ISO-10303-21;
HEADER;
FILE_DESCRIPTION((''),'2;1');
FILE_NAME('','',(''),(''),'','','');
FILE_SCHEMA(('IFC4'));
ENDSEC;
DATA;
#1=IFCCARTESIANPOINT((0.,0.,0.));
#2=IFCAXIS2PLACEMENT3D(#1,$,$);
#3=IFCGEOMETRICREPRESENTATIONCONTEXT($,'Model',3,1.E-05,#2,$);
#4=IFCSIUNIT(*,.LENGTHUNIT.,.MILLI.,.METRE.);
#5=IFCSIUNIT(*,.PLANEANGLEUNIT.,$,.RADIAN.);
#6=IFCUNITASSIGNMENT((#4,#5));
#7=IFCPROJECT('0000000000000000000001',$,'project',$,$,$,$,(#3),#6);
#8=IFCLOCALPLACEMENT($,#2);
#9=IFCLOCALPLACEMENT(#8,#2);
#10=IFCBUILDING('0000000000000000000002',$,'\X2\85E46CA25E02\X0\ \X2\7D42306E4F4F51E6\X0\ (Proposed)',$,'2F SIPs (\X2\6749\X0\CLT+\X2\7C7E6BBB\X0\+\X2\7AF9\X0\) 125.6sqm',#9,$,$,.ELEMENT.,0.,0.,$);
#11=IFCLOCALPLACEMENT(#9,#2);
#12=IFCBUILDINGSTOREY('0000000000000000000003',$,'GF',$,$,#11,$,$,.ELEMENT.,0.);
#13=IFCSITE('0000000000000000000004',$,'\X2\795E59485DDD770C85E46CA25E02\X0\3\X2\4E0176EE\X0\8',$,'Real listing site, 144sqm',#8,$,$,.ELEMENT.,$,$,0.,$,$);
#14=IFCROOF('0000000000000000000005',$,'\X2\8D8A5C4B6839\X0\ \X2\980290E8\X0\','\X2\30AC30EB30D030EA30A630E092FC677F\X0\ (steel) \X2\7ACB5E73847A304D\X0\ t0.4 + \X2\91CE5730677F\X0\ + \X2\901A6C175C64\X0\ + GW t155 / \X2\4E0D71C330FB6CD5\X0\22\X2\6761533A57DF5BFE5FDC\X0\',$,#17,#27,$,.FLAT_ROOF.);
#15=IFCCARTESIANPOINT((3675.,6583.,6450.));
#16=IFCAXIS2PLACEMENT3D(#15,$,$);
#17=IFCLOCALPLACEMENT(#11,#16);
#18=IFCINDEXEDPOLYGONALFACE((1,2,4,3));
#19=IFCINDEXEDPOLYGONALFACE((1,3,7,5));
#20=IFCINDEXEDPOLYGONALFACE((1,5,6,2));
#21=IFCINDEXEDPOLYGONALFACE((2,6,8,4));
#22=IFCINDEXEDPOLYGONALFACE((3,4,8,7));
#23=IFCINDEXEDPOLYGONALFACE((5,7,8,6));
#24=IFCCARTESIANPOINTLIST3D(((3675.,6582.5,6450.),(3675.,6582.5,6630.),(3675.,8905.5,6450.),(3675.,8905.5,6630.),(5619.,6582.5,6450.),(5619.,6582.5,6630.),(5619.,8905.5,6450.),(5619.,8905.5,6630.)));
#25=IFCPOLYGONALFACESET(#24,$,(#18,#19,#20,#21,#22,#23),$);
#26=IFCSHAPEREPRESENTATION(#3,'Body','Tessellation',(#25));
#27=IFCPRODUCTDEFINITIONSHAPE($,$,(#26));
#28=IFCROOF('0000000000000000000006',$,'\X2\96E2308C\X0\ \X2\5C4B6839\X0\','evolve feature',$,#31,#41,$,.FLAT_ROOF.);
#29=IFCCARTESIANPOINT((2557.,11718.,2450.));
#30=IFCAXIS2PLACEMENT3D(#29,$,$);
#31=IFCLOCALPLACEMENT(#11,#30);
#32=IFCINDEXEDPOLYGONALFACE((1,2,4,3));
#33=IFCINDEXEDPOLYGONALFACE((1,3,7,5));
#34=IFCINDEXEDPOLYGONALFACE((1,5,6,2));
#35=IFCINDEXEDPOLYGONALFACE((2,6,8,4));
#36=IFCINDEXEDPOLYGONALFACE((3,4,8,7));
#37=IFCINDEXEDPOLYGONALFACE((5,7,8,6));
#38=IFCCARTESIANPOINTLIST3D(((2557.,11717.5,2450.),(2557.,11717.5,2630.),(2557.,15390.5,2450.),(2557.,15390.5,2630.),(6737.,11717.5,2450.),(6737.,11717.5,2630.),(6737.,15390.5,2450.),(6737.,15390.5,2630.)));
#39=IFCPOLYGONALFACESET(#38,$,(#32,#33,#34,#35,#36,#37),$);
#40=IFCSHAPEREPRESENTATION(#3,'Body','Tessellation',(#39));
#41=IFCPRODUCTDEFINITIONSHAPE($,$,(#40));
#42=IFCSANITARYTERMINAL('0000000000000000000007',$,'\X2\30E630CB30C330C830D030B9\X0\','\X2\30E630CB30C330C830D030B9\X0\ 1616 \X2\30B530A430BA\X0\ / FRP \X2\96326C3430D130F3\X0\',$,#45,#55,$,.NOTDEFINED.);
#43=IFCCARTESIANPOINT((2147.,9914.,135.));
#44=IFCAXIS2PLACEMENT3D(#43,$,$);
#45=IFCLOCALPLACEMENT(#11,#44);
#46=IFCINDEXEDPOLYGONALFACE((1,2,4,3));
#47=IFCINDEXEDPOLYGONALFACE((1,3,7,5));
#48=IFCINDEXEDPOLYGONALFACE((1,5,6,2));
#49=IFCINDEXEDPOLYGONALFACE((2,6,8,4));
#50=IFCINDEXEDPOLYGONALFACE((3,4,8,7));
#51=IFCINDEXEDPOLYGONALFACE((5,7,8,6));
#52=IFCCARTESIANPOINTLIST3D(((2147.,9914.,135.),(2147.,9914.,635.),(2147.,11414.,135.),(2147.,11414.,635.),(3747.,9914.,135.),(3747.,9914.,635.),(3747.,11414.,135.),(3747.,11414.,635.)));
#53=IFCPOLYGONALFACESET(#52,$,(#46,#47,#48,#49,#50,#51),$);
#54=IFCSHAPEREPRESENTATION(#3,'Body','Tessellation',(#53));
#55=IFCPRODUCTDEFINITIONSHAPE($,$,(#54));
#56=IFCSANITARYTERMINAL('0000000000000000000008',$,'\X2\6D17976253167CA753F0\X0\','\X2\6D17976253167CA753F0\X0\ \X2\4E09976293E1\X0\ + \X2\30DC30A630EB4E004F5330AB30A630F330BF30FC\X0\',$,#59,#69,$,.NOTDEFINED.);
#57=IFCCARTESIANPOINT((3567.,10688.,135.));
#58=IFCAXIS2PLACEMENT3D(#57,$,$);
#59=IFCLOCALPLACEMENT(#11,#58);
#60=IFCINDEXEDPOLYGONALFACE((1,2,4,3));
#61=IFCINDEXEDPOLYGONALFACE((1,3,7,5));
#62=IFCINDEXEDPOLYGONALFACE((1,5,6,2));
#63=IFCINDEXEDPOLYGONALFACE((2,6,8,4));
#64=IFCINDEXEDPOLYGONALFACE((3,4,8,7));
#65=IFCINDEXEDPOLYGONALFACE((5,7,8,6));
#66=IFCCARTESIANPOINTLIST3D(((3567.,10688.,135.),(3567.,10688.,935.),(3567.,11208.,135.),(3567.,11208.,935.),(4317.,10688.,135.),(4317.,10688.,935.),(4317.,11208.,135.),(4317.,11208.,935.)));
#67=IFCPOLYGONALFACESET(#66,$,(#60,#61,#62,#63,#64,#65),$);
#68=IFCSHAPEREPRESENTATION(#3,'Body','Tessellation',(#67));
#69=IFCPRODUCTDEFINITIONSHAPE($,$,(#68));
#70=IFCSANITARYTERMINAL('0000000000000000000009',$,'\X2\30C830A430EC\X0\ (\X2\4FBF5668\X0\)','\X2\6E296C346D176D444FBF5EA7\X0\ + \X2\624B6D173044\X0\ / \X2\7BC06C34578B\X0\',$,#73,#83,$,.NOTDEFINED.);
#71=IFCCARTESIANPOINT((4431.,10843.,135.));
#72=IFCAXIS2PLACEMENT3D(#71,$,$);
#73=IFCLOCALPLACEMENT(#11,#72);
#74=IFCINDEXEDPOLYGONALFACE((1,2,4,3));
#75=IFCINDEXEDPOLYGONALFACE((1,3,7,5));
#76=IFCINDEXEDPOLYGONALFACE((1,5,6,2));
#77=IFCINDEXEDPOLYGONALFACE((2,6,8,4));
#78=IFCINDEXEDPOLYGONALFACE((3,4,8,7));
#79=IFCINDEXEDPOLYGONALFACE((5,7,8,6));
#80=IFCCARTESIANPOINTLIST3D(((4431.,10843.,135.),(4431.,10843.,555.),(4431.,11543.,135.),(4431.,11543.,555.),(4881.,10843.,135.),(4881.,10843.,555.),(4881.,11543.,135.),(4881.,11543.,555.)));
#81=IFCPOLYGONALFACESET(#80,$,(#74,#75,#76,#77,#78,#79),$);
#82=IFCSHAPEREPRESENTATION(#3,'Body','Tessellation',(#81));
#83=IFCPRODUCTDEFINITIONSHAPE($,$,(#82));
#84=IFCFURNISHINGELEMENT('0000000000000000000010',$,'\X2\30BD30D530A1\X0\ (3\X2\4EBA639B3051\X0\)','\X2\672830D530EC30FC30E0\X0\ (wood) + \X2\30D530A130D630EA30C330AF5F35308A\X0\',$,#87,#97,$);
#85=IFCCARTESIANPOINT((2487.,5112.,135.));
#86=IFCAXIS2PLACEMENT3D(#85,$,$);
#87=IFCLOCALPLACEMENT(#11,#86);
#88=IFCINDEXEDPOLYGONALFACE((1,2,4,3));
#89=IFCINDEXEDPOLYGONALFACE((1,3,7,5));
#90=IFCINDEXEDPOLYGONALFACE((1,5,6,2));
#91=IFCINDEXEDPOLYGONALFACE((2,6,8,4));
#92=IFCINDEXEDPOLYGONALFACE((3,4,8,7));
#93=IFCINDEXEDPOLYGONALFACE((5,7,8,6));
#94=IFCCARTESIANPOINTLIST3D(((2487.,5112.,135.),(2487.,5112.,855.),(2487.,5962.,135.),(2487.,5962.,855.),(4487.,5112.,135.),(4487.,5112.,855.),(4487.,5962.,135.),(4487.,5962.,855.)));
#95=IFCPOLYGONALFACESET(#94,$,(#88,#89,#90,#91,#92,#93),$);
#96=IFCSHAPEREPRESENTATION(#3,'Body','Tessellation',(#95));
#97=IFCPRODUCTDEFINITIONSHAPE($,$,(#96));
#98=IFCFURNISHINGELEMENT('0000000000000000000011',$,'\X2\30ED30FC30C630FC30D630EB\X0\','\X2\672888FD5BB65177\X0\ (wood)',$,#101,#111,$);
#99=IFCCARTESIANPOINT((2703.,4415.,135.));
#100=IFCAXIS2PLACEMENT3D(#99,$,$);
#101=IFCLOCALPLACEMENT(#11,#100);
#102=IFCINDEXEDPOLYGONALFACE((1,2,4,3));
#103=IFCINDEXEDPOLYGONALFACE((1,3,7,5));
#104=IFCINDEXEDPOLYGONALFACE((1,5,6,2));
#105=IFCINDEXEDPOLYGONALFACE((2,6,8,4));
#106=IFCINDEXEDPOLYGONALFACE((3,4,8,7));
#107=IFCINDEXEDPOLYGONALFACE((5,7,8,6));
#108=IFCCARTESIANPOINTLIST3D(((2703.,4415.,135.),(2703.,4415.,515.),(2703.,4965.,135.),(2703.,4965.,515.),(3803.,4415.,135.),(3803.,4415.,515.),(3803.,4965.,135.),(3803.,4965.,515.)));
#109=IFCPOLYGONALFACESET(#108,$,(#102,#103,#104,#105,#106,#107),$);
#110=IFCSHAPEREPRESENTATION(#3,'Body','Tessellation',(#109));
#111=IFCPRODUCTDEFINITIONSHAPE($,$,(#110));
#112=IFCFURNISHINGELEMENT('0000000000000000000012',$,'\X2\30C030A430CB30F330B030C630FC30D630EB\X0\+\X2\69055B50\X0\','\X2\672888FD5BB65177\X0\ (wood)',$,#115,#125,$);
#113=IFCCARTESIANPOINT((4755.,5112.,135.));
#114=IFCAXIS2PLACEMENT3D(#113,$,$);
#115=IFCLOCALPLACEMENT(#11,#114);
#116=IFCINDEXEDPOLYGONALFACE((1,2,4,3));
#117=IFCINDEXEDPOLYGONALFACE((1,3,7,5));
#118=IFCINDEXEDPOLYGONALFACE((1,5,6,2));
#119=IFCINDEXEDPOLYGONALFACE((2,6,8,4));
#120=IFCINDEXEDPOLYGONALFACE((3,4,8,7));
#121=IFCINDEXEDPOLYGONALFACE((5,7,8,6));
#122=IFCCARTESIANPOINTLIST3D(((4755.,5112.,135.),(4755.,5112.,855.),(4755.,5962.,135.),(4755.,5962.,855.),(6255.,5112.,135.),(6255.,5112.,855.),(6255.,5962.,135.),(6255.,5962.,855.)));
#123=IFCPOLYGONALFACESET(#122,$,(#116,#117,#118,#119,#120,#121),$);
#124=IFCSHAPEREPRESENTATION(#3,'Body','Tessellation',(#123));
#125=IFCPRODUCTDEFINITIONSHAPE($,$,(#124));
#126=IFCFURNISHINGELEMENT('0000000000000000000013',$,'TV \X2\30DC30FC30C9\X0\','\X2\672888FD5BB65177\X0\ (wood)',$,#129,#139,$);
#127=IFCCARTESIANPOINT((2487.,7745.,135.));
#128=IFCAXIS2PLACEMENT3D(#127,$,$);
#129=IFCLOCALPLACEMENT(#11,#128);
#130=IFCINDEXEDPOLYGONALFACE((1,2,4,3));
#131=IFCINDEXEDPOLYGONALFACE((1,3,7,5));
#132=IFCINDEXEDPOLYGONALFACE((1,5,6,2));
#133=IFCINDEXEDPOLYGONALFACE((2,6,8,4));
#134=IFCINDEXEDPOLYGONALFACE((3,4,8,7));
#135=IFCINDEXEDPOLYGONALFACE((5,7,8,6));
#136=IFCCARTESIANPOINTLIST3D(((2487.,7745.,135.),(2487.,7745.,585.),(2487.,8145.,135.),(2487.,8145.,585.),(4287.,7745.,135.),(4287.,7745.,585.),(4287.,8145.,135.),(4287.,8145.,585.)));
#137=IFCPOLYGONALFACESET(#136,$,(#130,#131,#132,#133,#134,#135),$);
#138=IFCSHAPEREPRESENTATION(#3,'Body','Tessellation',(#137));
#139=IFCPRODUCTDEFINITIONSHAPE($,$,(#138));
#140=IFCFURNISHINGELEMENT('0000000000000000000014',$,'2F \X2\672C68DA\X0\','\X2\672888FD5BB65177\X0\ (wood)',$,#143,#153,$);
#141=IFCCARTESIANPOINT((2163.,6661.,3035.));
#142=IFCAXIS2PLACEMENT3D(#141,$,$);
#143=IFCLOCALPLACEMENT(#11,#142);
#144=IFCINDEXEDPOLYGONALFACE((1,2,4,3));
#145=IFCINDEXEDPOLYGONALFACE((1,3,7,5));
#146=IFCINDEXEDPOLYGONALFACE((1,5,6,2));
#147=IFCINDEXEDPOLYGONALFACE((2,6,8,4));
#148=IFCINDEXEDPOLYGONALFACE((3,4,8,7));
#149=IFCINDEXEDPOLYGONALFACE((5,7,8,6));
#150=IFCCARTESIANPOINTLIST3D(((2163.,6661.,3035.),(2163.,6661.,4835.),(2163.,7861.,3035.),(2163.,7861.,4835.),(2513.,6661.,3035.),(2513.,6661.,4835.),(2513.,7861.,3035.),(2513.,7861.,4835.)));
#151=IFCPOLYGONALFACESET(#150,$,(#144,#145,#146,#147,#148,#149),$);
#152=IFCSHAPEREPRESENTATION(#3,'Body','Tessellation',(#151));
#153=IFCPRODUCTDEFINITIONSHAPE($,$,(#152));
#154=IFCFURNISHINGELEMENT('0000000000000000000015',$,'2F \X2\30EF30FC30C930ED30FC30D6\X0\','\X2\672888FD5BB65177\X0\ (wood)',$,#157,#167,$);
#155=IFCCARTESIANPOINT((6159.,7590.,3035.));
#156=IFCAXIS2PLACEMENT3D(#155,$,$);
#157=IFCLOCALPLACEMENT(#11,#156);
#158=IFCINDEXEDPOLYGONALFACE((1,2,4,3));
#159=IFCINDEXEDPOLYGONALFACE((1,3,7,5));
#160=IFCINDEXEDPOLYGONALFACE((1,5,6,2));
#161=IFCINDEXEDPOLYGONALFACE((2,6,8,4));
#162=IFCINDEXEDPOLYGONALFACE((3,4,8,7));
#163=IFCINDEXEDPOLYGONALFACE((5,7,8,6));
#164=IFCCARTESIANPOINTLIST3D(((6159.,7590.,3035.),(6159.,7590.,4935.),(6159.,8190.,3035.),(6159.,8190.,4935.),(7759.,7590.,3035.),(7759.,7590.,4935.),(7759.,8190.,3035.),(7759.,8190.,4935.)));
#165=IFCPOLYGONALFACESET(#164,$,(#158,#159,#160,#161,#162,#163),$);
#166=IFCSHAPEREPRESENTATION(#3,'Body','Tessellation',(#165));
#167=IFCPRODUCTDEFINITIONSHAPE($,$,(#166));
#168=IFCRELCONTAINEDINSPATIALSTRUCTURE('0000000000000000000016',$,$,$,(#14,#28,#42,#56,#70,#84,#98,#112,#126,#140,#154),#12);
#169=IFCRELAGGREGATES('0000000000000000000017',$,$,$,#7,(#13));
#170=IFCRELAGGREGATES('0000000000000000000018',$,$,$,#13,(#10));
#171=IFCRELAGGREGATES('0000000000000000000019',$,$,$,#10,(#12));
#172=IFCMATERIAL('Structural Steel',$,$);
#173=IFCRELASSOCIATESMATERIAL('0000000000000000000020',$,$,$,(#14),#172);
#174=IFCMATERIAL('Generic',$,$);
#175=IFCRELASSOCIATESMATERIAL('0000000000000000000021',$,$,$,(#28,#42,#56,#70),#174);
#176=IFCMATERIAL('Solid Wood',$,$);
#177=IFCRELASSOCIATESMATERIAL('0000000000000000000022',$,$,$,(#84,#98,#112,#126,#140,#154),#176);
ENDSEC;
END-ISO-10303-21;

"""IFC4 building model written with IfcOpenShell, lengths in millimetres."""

from ifc_helpers import new_model, si_unit, frame, frame_2d, origin, place, context, project, spatial, rectangle, extrude, material, element, save


model = new_model("IFC4")

# Units and contexts
model_context = context("Model", 3, precision=1e-05, world=origin())
ifc_project = project(units=[si_unit("LENGTHUNIT", "METRE", prefix="MILLI"), si_unit("PLANEANGLEUNIT", "RADIAN")], contexts=[model_context])

# Site, building, storey
site_placement = place(None, origin())
site = spatial("IfcSite", under=ifc_project, at=site_placement, Name="神奈川県藤沢市3丁目8", ObjectType="Real listing site, 144sqm", CompositionType="ELEMENT", RefElevation=0.0)
building_placement = place(site_placement, origin())
building = spatial("IfcBuilding", under=site, at=building_placement, Name="藤沢市 終の住処 (Proposed)", ObjectType="2F SIPs (杉CLT+籾殻+竹) 125.6sqm", CompositionType="ELEMENT", ElevationOfRefHeight=0.0, ElevationOfTerrain=0.0)
storey_placement = place(building_placement, origin())
storey = spatial("IfcBuildingStorey", under=building, at=storey_placement, Name="GF", CompositionType="ELEMENT", Elevation=0.0)

# Shared definitions
ifc_material_1 = material(Name="Generic")

# Shared definitions
ifc_material_2 = material(Name="Solid Wood")

# Roofs
ifc_material_3 = material(Name="Structural Steel")
roof_1_placement = place(storey_placement, frame((3675.0, 6583.0, 6450.0)))
element("IfcRoof", 1, at=roof_1_placement, inside=storey, material=ifc_material_3, Name="越屋根 頂部", Description="ガルバリウム鋼板 (steel) 立平葺き t0.4 + 野地板 + 通気層 + GW t155 / 不燃・法22条区域対応", PredefinedType="FLAT_ROOF", context=model_context, shape_type="SweptSolid", body=[
    extrude(rectangle(XDim=1944.0, YDim=2323.0, at=frame_2d((972.0, 1161.0))), frame((3675.0, 6583.0, 6450.0)), (0.0, 0.0, 1.0), 180.0),
])
roof_2_placement = place(storey_placement, frame((2557.0, 11718.0, 2450.0)))
element("IfcRoof", 2, at=roof_2_placement, inside=storey, material=ifc_material_1, Name="離れ 屋根", Description="evolve feature", PredefinedType="FLAT_ROOF", context=model_context, shape_type="SweptSolid", body=[
    extrude(rectangle(XDim=4180.0, YDim=3673.0, at=frame_2d((2090.0, 1836.0))), frame((2557.0, 11718.0, 2450.0)), (0.0, 0.0, 1.0), 180.0),
])

# Sanitary terminals
sanitary_terminal_1_placement = place(storey_placement, frame((2147.0, 9914.0, 135.0)))
element("IfcSanitaryTerminal", 3, at=sanitary_terminal_1_placement, inside=storey, material=ifc_material_1, Name="ユニットバス", Description="ユニットバス 1616 サイズ / FRP 防水パン", PredefinedType="NOTDEFINED", context=model_context, shape_type="SweptSolid", body=[
    extrude(rectangle(XDim=1600.0, YDim=1500.0, at=frame_2d((800.0, 750.0))), frame((2147.0, 9914.0, 135.0)), (0.0, 0.0, 1.0), 500.0),
])
sanitary_terminal_2_placement = place(storey_placement, frame((3567.0, 10688.0, 135.0)))
element("IfcSanitaryTerminal", 4, at=sanitary_terminal_2_placement, inside=storey, material=ifc_material_1, Name="洗面化粧台", Description="洗面化粧台 三面鏡 + ボウル一体カウンター", PredefinedType="NOTDEFINED", context=model_context, shape_type="SweptSolid", body=[
    extrude(rectangle(XDim=750.0, YDim=520.0, at=frame_2d((375.0, 260.0))), frame((3567.0, 10688.0, 135.0)), (0.0, 0.0, 1.0), 800.0),
])
sanitary_terminal_3_placement = place(storey_placement, frame((4431.0, 10843.0, 135.0)))
element("IfcSanitaryTerminal", 5, at=sanitary_terminal_3_placement, inside=storey, material=ifc_material_1, Name="トイレ (便器)", Description="温水洗浄便座 + 手洗い / 節水型", PredefinedType="NOTDEFINED", context=model_context, shape_type="SweptSolid", body=[
    extrude(rectangle(XDim=450.0, YDim=700.0, at=frame_2d((225.0, 350.0))), frame((4431.0, 10843.0, 135.0)), (0.0, 0.0, 1.0), 420.0),
])

# Furnishing elements
furnishing_1_placement = place(storey_placement, frame((2487.0, 5112.0, 135.0)))
element("IfcFurnishingElement", 6, at=furnishing_1_placement, inside=storey, material=ifc_material_2, Name="ソファ (3人掛け)", Description="木フレーム (wood) + ファブリック張り", context=model_context, shape_type="SweptSolid", body=[
    extrude(rectangle(XDim=2000.0, YDim=850.0, at=frame_2d((1000.0, 425.0))), frame((2487.0, 5112.0, 135.0)), (0.0, 0.0, 1.0), 720.0),
])
furnishing_2_placement = place(storey_placement, frame((2703.0, 4415.0, 135.0)))
element("IfcFurnishingElement", 7, at=furnishing_2_placement, inside=storey, material=ifc_material_2, Name="ローテーブル", Description="木製家具 (wood)", context=model_context, shape_type="SweptSolid", body=[
    extrude(rectangle(XDim=1100.0, YDim=550.0, at=frame_2d((550.0, 275.0))), frame((2703.0, 4415.0, 135.0)), (0.0, 0.0, 1.0), 380.0),
])
furnishing_3_placement = place(storey_placement, frame((4755.0, 5112.0, 135.0)))
element("IfcFurnishingElement", 8, at=furnishing_3_placement, inside=storey, material=ifc_material_2, Name="ダイニングテーブル+椅子", Description="木製家具 (wood)", context=model_context, shape_type="SweptSolid", body=[
    extrude(rectangle(XDim=1500.0, YDim=850.0, at=frame_2d((750.0, 425.0))), frame((4755.0, 5112.0, 135.0)), (0.0, 0.0, 1.0), 720.0),
])
furnishing_4_placement = place(storey_placement, frame((2487.0, 7745.0, 135.0)))
element("IfcFurnishingElement", 9, at=furnishing_4_placement, inside=storey, material=ifc_material_2, Name="TV ボード", Description="木製家具 (wood)", context=model_context, shape_type="SweptSolid", body=[
    extrude(rectangle(XDim=1800.0, YDim=400.0, at=frame_2d((900.0, 200.0))), frame((2487.0, 7745.0, 135.0)), (0.0, 0.0, 1.0), 450.0),
])
furnishing_5_placement = place(storey_placement, frame((2163.0, 6661.0, 3035.0)))
element("IfcFurnishingElement", 10, at=furnishing_5_placement, inside=storey, material=ifc_material_2, Name="2F 本棚", Description="木製家具 (wood)", context=model_context, shape_type="SweptSolid", body=[
    extrude(rectangle(XDim=350.0, YDim=1200.0, at=frame_2d((175.0, 600.0))), frame((2163.0, 6661.0, 3035.0)), (0.0, 0.0, 1.0), 1800.0),
])
furnishing_6_placement = place(storey_placement, frame((6159.0, 7590.0, 3035.0)))
element("IfcFurnishingElement", 11, at=furnishing_6_placement, inside=storey, material=ifc_material_2, Name="2F ワードローブ", Description="木製家具 (wood)", context=model_context, shape_type="SweptSolid", body=[
    extrude(rectangle(XDim=1600.0, YDim=600.0, at=frame_2d((800.0, 300.0))), frame((6159.0, 7590.0, 3035.0)), (0.0, 0.0, 1.0), 1900.0),
])

save(model, "model.ifc")
